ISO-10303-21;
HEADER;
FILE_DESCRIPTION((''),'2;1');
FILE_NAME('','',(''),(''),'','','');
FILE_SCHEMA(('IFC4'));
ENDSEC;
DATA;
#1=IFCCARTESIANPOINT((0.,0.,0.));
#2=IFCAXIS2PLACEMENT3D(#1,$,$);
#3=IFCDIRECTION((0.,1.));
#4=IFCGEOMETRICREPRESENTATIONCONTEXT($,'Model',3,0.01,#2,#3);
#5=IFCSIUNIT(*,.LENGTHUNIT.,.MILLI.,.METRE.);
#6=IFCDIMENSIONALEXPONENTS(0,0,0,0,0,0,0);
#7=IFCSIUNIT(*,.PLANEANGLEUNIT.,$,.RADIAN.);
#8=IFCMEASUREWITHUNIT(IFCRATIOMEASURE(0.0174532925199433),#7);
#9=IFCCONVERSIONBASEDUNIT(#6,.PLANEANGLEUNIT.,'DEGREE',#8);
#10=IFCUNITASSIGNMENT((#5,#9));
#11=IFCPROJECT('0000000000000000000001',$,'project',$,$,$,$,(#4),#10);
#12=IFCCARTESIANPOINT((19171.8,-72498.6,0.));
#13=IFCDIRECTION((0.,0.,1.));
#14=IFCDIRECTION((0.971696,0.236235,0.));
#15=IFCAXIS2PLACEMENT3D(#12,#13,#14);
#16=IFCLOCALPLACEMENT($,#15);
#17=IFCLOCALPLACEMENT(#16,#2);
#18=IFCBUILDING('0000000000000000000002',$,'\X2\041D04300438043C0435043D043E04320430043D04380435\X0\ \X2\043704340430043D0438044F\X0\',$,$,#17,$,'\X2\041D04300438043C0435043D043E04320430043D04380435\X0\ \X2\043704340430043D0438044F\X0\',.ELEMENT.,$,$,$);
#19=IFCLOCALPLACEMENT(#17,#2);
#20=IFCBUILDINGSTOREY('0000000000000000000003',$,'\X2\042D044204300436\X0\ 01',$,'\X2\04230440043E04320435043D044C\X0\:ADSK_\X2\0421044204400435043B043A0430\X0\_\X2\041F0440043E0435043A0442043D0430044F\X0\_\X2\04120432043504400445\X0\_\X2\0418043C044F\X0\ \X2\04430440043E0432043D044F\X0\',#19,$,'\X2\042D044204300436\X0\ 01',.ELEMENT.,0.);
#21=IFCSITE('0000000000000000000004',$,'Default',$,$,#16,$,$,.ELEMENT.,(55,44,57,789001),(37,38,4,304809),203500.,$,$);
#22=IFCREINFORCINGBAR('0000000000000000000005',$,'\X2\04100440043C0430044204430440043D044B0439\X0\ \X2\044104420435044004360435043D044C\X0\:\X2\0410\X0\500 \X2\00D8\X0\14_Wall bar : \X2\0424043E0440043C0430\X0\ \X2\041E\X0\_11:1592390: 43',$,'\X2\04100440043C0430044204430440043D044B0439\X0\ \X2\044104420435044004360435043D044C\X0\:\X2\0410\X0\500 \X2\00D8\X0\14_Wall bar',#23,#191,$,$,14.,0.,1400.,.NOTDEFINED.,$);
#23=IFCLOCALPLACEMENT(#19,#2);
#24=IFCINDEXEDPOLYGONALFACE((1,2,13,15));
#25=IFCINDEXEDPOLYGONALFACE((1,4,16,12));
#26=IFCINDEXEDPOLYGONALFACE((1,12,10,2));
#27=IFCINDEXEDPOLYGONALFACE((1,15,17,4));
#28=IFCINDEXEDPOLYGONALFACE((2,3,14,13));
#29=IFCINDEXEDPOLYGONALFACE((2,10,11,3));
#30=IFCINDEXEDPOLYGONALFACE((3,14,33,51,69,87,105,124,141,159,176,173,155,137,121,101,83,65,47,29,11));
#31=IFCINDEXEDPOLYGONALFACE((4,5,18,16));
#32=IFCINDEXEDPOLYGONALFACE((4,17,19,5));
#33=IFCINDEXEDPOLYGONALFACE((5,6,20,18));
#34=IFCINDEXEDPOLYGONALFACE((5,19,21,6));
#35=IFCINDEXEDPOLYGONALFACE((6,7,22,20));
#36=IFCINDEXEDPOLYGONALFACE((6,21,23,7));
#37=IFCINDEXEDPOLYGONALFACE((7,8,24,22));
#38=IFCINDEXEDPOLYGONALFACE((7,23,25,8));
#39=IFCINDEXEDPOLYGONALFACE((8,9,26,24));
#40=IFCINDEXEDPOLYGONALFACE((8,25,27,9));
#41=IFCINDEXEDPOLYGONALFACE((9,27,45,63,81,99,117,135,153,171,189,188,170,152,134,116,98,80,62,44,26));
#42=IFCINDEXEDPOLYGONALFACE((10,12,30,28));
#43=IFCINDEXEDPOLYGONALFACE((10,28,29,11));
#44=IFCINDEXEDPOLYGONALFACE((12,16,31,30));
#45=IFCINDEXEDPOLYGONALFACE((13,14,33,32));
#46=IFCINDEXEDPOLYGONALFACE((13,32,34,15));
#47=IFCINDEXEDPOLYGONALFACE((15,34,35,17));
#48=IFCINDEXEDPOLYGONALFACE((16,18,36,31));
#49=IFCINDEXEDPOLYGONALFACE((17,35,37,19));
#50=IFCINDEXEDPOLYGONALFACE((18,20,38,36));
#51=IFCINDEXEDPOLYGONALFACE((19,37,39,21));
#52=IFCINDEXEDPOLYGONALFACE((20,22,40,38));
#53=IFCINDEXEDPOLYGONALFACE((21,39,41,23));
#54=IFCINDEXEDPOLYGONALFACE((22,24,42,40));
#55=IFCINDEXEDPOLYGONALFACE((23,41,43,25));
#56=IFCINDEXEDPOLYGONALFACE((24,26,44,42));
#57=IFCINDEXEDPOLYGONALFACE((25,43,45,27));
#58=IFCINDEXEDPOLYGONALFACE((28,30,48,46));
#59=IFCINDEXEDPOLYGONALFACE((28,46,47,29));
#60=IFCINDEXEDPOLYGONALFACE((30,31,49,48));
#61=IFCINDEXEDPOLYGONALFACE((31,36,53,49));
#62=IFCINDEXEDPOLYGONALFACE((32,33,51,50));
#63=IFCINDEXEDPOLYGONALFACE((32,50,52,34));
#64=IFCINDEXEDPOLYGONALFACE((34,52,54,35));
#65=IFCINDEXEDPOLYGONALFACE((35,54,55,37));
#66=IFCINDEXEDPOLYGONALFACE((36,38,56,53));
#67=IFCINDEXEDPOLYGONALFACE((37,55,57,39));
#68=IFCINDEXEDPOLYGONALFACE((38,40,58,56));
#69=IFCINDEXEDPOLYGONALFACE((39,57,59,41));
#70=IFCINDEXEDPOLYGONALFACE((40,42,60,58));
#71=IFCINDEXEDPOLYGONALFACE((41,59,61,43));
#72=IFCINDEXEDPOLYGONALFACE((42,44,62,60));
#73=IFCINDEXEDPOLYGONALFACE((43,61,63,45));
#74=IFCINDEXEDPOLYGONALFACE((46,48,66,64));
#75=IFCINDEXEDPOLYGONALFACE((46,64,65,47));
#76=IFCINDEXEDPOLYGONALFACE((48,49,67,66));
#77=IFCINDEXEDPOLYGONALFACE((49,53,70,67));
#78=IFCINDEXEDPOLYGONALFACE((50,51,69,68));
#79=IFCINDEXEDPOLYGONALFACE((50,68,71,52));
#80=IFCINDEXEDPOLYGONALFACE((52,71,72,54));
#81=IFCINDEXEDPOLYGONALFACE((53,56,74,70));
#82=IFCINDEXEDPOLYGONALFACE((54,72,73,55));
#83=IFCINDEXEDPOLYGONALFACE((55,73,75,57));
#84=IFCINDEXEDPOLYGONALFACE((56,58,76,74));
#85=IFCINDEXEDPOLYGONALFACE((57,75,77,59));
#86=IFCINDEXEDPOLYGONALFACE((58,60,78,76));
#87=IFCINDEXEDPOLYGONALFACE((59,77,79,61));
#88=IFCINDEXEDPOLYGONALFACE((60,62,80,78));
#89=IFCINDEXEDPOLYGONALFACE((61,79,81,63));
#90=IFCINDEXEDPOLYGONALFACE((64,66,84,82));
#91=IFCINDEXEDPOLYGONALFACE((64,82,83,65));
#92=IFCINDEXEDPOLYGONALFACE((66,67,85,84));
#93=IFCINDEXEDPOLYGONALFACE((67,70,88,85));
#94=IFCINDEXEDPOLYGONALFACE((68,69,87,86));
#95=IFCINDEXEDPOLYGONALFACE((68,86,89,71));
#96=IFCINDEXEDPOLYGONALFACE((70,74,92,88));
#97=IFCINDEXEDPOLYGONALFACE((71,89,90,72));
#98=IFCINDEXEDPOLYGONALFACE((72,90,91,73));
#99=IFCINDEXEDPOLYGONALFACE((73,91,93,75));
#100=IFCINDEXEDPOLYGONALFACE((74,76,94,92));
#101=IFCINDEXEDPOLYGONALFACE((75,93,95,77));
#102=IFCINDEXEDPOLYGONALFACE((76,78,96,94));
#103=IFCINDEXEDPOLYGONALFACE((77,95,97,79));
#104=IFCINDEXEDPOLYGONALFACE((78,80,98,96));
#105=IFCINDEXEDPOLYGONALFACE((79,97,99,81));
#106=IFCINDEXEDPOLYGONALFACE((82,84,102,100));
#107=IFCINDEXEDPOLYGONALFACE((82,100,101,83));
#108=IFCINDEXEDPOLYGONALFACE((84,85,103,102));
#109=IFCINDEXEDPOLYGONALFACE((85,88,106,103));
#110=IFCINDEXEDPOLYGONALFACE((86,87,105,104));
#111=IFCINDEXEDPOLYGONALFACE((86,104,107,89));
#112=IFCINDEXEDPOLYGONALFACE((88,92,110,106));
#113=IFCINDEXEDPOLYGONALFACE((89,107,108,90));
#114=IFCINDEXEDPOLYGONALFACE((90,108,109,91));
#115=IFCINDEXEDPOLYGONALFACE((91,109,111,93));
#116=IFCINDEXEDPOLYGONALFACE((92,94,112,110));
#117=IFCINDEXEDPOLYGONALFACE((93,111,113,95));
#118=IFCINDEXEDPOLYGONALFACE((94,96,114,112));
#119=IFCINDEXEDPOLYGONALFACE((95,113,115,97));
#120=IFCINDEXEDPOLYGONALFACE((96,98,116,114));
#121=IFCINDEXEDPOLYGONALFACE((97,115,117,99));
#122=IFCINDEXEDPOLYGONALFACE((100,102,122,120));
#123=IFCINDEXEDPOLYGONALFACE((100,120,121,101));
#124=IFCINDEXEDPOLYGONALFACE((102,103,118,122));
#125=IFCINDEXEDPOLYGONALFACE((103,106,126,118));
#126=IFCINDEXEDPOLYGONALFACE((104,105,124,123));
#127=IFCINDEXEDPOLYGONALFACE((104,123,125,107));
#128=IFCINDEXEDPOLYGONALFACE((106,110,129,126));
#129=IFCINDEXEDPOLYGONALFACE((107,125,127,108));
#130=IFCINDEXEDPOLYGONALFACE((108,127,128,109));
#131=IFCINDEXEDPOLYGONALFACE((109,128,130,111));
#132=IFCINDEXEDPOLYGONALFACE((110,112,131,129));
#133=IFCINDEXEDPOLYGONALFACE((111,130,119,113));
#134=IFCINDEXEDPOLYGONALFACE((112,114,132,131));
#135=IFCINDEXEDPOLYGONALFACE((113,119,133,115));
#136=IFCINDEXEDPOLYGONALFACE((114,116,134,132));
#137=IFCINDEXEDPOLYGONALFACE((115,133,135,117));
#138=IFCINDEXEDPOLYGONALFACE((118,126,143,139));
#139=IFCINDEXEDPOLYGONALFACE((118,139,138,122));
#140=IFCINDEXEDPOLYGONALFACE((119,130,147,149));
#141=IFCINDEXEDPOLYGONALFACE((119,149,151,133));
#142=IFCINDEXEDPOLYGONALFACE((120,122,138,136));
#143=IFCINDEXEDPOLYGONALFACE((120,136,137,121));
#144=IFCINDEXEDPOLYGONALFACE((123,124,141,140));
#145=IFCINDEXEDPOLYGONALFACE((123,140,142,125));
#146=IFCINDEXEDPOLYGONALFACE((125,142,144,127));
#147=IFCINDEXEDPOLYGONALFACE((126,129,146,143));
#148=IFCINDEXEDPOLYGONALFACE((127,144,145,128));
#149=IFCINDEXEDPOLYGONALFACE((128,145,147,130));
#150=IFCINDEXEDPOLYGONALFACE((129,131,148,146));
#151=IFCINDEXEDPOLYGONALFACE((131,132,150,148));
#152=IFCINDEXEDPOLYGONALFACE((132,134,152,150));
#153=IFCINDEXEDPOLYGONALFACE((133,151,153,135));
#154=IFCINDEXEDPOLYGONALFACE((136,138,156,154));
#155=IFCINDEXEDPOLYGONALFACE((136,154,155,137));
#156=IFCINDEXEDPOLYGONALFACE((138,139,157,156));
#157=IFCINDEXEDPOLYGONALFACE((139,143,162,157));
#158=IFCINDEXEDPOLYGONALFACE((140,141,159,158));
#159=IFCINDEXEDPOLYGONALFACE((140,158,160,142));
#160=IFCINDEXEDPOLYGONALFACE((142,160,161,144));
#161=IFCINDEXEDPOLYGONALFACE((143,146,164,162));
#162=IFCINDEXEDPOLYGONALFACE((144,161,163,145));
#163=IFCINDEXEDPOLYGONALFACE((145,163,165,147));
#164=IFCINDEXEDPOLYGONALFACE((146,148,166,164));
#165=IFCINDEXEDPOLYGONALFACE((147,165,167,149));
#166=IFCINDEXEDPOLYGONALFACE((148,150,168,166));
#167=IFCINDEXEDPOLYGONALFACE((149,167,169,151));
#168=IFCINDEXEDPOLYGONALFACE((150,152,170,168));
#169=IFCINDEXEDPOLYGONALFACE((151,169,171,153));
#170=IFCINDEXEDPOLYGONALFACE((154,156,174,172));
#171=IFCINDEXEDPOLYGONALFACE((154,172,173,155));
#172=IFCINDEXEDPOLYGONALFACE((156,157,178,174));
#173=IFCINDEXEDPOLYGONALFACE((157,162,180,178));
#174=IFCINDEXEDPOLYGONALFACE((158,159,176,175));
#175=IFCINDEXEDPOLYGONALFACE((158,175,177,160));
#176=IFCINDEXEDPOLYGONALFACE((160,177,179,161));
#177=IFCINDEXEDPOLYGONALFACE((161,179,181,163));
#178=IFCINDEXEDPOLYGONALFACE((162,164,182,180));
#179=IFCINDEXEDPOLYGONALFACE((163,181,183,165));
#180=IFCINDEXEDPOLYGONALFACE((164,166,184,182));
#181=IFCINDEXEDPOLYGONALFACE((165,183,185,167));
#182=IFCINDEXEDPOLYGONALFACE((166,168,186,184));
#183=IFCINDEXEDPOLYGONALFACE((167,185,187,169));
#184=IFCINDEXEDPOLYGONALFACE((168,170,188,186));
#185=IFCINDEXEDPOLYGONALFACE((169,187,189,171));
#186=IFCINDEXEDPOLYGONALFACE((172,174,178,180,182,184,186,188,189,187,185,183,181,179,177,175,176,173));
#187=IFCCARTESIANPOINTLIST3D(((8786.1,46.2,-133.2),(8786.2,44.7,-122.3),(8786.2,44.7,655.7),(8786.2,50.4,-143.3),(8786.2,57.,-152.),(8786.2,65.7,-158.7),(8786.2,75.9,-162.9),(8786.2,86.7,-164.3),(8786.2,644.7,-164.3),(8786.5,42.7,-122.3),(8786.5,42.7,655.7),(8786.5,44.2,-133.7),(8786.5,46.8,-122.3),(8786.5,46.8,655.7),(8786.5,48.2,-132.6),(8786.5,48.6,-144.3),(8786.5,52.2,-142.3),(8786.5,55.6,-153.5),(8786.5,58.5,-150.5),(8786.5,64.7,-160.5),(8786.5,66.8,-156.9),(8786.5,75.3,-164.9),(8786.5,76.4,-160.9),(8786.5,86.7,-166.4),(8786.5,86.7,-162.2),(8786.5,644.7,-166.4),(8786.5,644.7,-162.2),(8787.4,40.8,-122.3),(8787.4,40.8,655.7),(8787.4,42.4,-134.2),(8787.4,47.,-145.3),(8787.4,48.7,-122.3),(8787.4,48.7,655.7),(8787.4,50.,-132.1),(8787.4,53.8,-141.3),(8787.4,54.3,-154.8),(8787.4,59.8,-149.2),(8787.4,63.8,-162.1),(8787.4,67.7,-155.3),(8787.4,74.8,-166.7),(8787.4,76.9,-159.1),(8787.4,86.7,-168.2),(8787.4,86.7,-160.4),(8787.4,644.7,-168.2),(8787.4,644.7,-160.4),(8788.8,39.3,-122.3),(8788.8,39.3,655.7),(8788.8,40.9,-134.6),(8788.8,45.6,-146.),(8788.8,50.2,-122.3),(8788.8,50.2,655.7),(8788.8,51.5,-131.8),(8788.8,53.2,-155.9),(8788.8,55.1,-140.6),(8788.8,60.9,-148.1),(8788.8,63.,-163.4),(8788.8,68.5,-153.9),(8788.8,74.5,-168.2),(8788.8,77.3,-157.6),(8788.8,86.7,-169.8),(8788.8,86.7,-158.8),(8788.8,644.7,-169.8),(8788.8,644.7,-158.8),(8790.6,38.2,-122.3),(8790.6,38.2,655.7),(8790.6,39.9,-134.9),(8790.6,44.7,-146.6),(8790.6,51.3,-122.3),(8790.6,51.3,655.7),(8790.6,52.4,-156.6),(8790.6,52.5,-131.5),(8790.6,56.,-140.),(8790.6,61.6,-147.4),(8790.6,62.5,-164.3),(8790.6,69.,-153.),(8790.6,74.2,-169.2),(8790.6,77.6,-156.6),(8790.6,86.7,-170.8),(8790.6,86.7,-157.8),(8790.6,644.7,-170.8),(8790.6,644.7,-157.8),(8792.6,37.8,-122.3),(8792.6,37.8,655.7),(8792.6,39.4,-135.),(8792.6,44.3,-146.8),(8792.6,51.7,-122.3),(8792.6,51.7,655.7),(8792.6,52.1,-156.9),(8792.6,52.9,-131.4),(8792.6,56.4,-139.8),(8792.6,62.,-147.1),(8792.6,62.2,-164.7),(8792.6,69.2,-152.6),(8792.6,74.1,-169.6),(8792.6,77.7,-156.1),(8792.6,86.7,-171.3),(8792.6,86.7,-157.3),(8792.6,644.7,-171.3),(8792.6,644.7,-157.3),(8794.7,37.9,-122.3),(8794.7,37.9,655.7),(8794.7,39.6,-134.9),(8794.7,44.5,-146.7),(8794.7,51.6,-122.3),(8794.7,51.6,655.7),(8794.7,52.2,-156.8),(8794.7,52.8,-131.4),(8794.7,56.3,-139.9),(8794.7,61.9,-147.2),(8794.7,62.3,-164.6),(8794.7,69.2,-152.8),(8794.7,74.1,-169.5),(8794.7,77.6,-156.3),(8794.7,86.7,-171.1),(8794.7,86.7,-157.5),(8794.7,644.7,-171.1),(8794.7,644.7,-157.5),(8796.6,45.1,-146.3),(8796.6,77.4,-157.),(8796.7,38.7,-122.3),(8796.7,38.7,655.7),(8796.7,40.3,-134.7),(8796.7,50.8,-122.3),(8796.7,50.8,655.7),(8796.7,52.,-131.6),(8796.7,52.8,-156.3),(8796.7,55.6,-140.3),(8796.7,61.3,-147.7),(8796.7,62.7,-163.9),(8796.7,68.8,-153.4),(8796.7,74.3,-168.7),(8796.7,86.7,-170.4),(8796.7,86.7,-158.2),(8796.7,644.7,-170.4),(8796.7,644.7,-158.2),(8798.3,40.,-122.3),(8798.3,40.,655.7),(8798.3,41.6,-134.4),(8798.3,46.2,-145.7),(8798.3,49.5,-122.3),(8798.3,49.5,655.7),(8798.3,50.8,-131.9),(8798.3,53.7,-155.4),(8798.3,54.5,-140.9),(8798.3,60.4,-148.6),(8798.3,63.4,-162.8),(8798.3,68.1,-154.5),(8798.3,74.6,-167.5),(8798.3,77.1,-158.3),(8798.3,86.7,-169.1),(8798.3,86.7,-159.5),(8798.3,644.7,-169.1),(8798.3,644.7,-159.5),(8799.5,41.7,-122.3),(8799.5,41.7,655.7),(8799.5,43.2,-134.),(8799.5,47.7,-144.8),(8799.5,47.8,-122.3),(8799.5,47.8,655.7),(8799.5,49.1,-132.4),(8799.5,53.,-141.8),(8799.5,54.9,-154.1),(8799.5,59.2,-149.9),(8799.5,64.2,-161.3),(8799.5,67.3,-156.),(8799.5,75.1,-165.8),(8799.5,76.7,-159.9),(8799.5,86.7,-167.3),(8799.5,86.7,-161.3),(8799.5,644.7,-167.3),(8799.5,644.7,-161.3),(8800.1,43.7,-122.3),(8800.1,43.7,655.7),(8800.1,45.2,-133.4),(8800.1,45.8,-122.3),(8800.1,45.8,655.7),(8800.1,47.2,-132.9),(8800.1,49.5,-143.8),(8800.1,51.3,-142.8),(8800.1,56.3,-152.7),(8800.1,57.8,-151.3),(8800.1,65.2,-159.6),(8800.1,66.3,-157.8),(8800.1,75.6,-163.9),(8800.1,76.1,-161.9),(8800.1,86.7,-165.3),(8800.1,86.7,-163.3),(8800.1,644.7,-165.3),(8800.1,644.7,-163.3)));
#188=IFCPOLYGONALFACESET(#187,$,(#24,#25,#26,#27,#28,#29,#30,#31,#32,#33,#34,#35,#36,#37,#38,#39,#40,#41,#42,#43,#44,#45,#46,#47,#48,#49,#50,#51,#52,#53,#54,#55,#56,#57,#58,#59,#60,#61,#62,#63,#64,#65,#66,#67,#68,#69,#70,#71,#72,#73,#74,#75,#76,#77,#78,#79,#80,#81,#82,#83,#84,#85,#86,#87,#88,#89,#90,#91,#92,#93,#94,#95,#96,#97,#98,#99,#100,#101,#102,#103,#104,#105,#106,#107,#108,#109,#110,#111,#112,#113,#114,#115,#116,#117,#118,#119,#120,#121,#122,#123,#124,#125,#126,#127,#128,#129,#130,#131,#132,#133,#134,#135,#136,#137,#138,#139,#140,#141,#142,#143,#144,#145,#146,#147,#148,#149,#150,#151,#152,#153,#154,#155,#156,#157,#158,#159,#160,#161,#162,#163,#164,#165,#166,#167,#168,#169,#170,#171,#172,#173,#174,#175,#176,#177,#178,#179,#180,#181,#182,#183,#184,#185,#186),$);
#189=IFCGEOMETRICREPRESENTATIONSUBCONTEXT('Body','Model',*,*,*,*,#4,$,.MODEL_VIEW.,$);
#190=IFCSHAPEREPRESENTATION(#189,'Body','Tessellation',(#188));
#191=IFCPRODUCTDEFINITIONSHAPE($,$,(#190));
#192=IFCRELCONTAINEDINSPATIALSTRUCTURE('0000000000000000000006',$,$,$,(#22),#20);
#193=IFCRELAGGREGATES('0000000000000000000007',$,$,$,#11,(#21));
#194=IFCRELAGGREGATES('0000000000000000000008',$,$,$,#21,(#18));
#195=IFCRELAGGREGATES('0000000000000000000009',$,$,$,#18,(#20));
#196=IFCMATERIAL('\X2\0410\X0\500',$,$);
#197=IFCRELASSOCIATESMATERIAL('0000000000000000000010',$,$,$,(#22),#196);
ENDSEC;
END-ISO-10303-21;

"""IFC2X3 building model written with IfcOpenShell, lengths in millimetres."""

from ifc_helpers import new_model, entity, si_unit, converted_unit, direction, frame, origin, place, context, subcontext, project, spatial, material, element, save


model = new_model("IFC2X3")

# Units and contexts
model_context = context("Model", 3, precision=0.01, world=origin(), true_north=direction((0.0, 1.0)))
body_context = subcontext(model_context, "Body", "Model", "MODEL_VIEW")
ifc_project = project(units=[si_unit("LENGTHUNIT", "METRE", prefix="MILLI"), converted_unit("PLANEANGLEUNIT", "DEGREE", entity("IfcRatioMeasure", 0.0174532925199433), si_unit("PLANEANGLEUNIT", "RADIAN"), dimensions=[0, 0, 0, 0, 0, 0, 0])], contexts=[model_context])

# Site, building, storey
site_placement = place(None, frame((19171.8, -72498.6, 0.0), z_axis=(0.0, 0.0, 1.0), x_axis=(0.971696, 0.236235, 0.0)))
site = spatial("IfcSite", under=ifc_project, at=site_placement, Name="Default", CompositionType="ELEMENT", RefLatitude=(55, 44, 57, 789001), RefLongitude=(37, 38, 4, 304809), RefElevation=203500.0)
building_placement = place(site_placement, origin())
building = spatial("IfcBuilding", under=site, at=building_placement, Name="Наименование здания", LongName="Наименование здания", CompositionType="ELEMENT")
storey_placement = place(building_placement, origin())
storey = spatial("IfcBuildingStorey", under=building, at=storey_placement, Name="Этаж 01", ObjectType="Уровень:ADSK_Стрелка_Проектная_Вверх_Имя уровня", LongName="Этаж 01", CompositionType="ELEMENT", Elevation=0.0)

# Reinforcing bar
ifc_material = material(Name="А500")
placement = place(storey_placement, origin())
element("IfcReinforcingBar", 1, at=placement, inside=storey, material=ifc_material, Name="Арматурный стержень:А500 Ø14_Wall bar : Форма О_11:1592390: 43", ObjectType="Арматурный стержень:А500 Ø14_Wall bar", BarLength=1400.0, BarRole="NOTDEFINED", CrossSectionArea=0.0, NominalDiameter=14.0, context=body_context, shape_type="AdvancedSweptSolid", body=[
    entity("IfcSweptDiskSolid", entity("IfcCompositeCurve", [entity("IfcCompositeCurveSegment", "CONTINUOUS", True, entity("IfcPolyline", [entity("IfcCartesianPoint", [8793.1, 44.7, 655.7]), entity("IfcCartesianPoint", [8793.1, 44.7, -122.3])])), entity("IfcCompositeCurveSegment", "CONTINUOUS", True, entity("IfcTrimmedCurve", entity("IfcCircle", entity("IfcAxis2Placement3D", entity("IfcCartesianPoint", [8793.1, 86.7, -122.3]), entity("IfcDirection", [1.0, 0.0, 0.0]), entity("IfcDirection", [0.0, 0.0, -1.0])), 42.0), [entity("IfcParameterValue", 270.0)], [entity("IfcParameterValue", 360.0)], True, "PARAMETER")), entity("IfcCompositeCurveSegment", "CONTINUOUS", True, entity("IfcPolyline", [entity("IfcCartesianPoint", [8793.1, 86.7, -164.3]), entity("IfcCartesianPoint", [8793.1, 644.7, -164.3])]))], False), 7.0, None, 0.0, 92.0),
])

save(model, "model.ifc")
